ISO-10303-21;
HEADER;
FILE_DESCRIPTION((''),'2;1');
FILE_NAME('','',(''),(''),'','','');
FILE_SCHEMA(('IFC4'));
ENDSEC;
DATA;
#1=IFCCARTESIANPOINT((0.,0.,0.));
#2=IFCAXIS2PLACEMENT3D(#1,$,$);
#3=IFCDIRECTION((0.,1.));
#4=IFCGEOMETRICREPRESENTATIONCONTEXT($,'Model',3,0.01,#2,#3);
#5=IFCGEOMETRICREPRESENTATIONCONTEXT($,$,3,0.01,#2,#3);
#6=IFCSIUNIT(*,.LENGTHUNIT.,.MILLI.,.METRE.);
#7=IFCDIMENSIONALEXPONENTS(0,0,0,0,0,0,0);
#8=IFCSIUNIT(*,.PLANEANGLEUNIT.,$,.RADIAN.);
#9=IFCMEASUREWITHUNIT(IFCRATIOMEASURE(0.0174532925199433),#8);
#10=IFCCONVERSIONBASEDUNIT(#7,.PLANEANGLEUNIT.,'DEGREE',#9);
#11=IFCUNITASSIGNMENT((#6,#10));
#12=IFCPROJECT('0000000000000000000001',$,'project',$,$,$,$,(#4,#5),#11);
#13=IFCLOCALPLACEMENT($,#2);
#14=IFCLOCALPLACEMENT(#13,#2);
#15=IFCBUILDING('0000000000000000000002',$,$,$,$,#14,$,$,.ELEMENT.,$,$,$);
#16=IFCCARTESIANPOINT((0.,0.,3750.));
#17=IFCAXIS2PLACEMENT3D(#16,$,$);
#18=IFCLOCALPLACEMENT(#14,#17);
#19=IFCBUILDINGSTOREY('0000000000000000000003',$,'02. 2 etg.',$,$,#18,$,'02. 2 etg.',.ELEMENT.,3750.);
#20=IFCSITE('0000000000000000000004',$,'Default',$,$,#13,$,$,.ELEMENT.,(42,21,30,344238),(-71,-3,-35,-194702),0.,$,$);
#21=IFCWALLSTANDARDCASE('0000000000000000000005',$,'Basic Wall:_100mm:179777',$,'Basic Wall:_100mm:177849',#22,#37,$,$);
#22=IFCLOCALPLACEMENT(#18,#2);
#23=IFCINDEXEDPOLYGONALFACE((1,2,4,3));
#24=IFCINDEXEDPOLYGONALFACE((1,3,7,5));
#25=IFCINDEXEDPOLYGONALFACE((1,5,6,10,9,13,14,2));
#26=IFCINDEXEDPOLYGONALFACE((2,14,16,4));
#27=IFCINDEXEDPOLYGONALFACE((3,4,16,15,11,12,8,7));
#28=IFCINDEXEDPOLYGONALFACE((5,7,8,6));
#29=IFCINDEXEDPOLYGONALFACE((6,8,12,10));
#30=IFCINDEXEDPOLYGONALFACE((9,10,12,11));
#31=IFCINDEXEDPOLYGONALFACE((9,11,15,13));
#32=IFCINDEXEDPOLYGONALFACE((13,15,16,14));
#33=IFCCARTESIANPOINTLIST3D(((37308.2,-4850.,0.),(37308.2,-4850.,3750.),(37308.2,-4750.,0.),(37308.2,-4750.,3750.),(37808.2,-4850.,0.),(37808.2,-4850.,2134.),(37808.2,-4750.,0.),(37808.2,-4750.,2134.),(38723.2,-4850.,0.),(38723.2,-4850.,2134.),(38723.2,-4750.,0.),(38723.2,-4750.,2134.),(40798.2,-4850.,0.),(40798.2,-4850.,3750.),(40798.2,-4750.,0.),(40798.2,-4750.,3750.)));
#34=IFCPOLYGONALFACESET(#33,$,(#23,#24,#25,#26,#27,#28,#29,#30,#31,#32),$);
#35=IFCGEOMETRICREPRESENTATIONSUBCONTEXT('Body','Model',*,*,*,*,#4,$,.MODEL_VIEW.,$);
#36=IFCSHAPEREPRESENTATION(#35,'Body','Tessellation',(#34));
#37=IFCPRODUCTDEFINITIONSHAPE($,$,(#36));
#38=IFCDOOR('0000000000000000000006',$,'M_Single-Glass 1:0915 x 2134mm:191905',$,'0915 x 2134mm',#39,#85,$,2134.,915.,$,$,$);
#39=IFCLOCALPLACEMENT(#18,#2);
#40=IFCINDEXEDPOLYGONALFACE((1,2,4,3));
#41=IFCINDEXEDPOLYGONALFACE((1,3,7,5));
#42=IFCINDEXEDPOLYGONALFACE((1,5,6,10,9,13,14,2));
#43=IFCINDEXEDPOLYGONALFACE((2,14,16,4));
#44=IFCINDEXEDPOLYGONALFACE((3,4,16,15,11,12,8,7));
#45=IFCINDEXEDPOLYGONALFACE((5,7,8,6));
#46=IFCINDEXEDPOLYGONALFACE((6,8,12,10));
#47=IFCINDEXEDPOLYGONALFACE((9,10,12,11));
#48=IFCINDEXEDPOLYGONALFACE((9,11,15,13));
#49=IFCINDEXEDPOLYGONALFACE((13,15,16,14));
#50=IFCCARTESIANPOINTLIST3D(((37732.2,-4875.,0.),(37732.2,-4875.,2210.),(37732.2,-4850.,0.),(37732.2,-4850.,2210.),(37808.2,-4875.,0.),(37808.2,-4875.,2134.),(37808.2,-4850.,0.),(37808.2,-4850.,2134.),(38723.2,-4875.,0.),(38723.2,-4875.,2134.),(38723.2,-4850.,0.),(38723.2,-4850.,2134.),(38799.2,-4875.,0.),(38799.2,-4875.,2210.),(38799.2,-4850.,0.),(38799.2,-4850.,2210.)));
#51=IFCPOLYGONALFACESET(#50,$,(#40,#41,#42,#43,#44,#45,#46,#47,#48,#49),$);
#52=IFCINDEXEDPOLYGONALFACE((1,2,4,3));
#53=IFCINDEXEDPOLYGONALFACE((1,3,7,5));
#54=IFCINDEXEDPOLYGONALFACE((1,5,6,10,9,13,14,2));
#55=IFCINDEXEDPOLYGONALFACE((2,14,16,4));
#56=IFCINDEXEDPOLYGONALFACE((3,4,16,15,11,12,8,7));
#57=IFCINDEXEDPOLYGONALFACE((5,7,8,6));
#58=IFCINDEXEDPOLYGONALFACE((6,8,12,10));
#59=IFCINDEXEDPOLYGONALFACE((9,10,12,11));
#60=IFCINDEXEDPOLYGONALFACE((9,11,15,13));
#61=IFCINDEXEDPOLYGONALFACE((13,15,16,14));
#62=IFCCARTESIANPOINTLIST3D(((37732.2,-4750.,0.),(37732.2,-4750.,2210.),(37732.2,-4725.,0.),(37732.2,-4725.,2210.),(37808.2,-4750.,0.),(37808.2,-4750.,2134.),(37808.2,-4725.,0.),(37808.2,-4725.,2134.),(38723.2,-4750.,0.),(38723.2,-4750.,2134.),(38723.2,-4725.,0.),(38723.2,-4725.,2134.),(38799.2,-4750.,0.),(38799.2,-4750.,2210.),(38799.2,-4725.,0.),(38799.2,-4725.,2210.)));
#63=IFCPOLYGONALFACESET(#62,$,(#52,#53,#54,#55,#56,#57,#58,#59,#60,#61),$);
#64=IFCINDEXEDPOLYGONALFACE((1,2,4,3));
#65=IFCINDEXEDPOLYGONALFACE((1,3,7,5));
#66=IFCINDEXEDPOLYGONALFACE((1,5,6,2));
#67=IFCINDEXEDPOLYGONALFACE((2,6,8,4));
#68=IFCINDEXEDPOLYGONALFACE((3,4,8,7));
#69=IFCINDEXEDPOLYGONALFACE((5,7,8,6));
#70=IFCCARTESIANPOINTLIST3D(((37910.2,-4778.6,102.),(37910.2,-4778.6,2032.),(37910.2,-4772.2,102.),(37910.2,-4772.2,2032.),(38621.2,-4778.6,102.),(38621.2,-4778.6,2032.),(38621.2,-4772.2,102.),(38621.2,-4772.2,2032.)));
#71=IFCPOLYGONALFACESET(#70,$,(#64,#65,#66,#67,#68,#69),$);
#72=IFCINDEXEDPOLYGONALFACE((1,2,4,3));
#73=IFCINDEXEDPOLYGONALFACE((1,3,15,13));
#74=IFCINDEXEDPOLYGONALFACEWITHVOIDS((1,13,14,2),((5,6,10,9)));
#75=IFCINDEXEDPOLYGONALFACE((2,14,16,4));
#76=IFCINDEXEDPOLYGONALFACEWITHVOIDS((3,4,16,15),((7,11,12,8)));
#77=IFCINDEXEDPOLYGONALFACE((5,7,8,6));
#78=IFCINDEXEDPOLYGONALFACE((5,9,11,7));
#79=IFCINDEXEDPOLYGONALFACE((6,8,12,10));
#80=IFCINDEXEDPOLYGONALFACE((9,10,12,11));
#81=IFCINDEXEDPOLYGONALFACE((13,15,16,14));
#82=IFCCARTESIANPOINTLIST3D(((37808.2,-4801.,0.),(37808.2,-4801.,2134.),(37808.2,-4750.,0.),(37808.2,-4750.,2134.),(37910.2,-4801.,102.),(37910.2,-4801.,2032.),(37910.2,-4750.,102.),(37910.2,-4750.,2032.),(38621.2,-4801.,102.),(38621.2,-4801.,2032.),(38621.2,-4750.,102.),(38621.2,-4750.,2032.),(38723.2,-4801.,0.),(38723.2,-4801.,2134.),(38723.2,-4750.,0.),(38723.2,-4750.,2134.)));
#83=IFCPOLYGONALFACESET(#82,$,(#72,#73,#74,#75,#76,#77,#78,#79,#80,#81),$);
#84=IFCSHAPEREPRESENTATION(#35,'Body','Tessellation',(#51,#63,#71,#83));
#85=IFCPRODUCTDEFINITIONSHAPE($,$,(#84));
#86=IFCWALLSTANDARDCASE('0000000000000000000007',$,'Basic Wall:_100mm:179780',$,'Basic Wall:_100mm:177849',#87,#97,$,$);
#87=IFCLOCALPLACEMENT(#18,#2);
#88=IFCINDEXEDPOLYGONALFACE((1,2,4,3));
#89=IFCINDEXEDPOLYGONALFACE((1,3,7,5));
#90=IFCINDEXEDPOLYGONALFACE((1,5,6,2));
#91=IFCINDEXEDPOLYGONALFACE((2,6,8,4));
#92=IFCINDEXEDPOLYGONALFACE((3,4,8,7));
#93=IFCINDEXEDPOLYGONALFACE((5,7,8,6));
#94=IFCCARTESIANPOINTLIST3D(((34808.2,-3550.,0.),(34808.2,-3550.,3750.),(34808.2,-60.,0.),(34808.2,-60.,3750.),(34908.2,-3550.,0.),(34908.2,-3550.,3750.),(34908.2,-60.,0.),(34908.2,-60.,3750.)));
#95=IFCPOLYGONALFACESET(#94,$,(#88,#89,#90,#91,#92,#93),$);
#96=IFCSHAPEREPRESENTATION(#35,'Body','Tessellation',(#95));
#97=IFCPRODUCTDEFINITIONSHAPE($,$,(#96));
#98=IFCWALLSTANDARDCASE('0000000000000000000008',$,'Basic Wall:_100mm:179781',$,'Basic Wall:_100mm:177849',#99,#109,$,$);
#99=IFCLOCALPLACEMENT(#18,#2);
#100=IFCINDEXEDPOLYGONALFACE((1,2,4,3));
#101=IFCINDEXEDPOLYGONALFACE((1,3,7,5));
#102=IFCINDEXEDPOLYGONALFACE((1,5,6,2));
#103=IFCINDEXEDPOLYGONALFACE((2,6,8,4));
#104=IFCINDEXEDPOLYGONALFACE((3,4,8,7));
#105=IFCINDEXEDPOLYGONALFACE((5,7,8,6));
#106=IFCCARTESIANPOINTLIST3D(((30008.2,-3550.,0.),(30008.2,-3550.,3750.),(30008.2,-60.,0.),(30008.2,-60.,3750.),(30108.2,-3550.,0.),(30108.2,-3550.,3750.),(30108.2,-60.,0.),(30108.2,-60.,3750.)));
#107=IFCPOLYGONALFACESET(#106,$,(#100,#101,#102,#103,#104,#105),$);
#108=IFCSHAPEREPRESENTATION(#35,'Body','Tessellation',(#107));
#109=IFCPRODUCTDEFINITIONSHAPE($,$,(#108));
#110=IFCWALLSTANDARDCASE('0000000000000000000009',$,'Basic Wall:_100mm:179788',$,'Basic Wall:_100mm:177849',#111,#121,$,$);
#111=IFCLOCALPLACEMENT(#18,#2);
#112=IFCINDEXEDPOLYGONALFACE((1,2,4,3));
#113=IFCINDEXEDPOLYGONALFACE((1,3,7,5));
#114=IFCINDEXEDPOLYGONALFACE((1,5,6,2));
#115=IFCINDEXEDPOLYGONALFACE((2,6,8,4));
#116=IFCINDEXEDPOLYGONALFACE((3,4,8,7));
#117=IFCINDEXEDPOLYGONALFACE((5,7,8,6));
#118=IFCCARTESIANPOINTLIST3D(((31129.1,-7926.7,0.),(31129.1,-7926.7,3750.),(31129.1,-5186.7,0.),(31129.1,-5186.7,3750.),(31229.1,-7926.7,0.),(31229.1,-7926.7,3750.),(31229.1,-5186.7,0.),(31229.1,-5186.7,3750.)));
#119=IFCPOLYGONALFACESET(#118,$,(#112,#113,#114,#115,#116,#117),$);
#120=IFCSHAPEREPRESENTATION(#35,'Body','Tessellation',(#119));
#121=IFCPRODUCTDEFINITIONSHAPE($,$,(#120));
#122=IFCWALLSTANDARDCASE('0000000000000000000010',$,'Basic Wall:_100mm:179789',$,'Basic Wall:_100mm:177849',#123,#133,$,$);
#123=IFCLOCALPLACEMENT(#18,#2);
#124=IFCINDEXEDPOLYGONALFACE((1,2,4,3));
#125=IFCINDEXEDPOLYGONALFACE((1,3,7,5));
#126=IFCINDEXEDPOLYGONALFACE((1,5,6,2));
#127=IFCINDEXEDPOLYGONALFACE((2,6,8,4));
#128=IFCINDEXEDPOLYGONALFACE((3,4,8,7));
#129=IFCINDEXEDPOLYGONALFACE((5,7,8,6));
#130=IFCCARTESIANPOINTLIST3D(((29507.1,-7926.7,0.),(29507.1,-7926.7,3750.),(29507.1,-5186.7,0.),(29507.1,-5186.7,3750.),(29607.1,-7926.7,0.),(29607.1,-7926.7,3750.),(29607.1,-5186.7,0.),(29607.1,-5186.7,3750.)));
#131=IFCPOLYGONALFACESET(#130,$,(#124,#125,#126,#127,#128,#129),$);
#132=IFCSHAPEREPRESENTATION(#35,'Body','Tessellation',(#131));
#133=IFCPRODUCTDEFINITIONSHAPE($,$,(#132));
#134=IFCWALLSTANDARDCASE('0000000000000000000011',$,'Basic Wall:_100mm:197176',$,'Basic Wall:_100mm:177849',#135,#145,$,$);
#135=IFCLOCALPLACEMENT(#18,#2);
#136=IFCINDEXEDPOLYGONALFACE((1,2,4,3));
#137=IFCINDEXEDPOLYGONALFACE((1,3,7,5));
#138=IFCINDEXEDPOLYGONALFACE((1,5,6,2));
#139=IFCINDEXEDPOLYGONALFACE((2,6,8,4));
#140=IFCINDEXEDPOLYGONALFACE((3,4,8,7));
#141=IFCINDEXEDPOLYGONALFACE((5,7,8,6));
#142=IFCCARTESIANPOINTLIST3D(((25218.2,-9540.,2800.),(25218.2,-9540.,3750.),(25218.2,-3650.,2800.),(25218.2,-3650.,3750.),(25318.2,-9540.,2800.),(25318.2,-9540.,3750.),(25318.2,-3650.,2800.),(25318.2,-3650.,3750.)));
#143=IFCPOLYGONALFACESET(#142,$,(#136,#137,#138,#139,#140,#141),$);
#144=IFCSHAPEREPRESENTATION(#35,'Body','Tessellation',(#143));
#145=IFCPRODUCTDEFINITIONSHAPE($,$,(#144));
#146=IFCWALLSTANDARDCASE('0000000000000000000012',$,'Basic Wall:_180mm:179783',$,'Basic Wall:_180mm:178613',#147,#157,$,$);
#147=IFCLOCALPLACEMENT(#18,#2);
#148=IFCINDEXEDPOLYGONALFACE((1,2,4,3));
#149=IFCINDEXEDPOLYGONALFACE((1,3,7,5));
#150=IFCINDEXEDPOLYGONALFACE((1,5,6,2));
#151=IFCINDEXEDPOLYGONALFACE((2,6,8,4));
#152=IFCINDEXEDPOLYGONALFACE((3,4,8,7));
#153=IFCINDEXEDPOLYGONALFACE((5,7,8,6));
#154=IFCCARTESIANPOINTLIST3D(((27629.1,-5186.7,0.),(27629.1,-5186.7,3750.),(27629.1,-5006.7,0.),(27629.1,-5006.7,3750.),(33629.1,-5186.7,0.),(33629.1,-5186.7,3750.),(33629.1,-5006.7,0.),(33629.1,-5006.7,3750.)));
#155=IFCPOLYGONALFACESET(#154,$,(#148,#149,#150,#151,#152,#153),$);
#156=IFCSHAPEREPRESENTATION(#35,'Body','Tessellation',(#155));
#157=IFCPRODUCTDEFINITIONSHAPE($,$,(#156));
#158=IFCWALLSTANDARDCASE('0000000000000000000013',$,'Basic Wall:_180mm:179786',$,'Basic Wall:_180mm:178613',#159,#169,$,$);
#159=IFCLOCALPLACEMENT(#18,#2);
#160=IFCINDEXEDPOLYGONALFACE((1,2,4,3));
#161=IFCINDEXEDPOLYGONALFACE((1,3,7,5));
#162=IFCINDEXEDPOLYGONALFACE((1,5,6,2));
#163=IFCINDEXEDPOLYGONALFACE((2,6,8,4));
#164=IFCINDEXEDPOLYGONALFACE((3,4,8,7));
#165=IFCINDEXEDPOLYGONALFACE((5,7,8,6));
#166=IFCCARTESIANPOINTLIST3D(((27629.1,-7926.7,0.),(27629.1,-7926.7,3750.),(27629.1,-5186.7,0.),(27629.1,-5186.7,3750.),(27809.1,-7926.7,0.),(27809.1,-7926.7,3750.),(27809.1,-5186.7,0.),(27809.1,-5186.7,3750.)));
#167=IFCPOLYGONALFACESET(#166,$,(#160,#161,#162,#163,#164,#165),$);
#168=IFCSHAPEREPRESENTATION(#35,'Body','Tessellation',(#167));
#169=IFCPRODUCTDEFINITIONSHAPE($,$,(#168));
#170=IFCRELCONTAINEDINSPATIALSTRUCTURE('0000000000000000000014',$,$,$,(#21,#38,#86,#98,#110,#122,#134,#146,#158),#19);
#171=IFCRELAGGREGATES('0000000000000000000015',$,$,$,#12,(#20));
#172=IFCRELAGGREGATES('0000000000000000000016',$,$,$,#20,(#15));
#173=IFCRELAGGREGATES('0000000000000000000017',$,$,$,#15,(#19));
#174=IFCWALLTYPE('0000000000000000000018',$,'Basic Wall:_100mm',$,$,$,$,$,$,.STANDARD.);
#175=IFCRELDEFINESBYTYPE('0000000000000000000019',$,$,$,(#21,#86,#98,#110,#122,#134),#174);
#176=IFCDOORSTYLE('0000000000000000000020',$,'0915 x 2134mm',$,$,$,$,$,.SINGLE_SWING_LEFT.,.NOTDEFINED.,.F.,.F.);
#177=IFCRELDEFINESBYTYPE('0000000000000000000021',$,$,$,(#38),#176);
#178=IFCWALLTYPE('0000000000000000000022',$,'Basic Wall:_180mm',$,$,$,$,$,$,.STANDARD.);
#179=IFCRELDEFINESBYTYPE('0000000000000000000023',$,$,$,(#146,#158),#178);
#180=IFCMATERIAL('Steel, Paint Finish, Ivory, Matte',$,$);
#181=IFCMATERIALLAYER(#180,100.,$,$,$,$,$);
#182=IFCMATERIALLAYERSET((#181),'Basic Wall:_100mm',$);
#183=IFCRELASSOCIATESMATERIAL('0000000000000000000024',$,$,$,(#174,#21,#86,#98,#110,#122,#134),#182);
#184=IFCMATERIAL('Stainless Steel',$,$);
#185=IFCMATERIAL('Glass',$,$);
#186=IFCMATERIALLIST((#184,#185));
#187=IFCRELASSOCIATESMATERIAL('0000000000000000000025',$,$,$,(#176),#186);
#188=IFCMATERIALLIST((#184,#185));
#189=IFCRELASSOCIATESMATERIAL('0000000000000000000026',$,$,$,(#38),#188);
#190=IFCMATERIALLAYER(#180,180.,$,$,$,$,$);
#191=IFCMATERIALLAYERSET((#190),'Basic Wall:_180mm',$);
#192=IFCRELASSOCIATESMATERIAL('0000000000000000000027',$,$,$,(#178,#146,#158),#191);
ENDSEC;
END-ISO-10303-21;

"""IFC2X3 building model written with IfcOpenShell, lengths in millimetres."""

from ifc_helpers import new_model, entity, si_unit, converted_unit, direction, frame, frame_2d, origin, origin_2d_with_axis, place, context, subcontext, project, spatial, polyline, rectangle, outline, extrude, source, transform, mapped, material, material_list, layer, layer_set, layer_usage, type_object, type_shapes, element, fill, save


model = new_model("IFC2X3")

# Units and contexts
model_context = context("Model", 3, precision=0.01, world=origin(), true_north=direction((0.0, 1.0)))
context_of_model = context(None, 3, precision=0.01, world=origin(), true_north=direction((0.0, 1.0)))
body_context = subcontext(model_context, "Body", "Model", "MODEL_VIEW")
ifc_project = project(units=[si_unit("LENGTHUNIT", "METRE", prefix="MILLI"), converted_unit("PLANEANGLEUNIT", "DEGREE", entity("IfcRatioMeasure", 0.0174532925199433), si_unit("PLANEANGLEUNIT", "RADIAN"), dimensions=[0, 0, 0, 0, 0, 0, 0])], contexts=[model_context, context_of_model])

# Site, building, storey
site_placement = place(None, origin())
site = spatial("IfcSite", under=ifc_project, at=site_placement, Name="Default", CompositionType="ELEMENT", RefLatitude=(42, 21, 30, 344238), RefLongitude=(-71, -3, -35, -194702), RefElevation=0.0)
building_placement = place(site_placement, origin())
building = spatial("IfcBuilding", under=site, at=building_placement, CompositionType="ELEMENT")
storey_placement = place(building_placement, frame((0.0, 0.0, 3750.0)))
storey = spatial("IfcBuildingStorey", under=building, at=storey_placement, Name="02. 2 etg.", LongName="02. 2 etg.", CompositionType="ELEMENT", Elevation=3750.0)

# Shared definitions
ifc_material_1 = material(Name="Glass")
ifc_material_2 = material(Name="Stainless Steel")

# Shared definitions
ifc_material_3 = material(Name="Steel, Paint Finish, Ivory, Matte")
ifc_layer_1 = layer(ifc_material_3, 100.0)
ifc_layer_set_1 = layer_set([ifc_layer_1], Name="Basic Wall:_100mm")
wall_type_1 = type_object("IfcWallType", Name="Basic Wall:_100mm", PredefinedType="STANDARD", material=ifc_layer_set_1)

# Wall, opening, door
ifc_layer_usage_1 = layer_usage(ifc_layer_set_1, "AXIS2", "POSITIVE", -50.0)
wall_1_placement = place(storey_placement, frame((37308.2, -4800.0, 0.0)))
wall_1 = element("IfcWallStandardCase", 1, at=wall_1_placement, inside=storey, type_object=wall_type_1, material=ifc_layer_usage_1, Name="Basic Wall:_100mm:179777", ObjectType="Basic Wall:_100mm:177849", context=body_context, shape_type="SweptSolid", body=[
    extrude(rectangle(XDim=3490.0, YDim=100.0, at=frame_2d((1745.0, 0.0), x_axis=(-1.0, 0.0))), origin(), (0.0, 0.0, 1.0), 3750.0),
])
opening_1_placement = place(wall_1_placement, frame((500.0, -50.0, 0.0)))
opening_1 = element("IfcOpeningElement", 2, at=opening_1_placement, cuts=wall_1, ObjectType="Opening", context=body_context, shape_type="SweptSolid", body=[
    extrude(rectangle(XDim=915.0, YDim=2134.0, at=frame_2d((1067.0, 457.5), x_axis=(0.0, -1.0))), frame((0.0, 0.0, 0.0), z_axis=(0.0, 1.0, 0.0), x_axis=(0.0, 0.0, 1.0)), (0.0, 0.0, 1.0), 100.0),
])
ifc_material_list_1 = material_list([ifc_material_2, ifc_material_1])
ifc_material_list_2 = material_list([ifc_material_2, ifc_material_1])
door_style_1 = type_object("IfcDoorStyle", Name="0915 x 2134mm", ConstructionType="NOTDEFINED", OperationType="SINGLE_SWING_LEFT", ParameterTakesPrecedence=False, Sizeable=False, material=ifc_material_list_2)
shared_shape_1 = source(origin(), body_context, "Body", "SweptSolid", [
    extrude(outline(polyline([(-457.5, -1048.0), (-457.5, 1086.0), (-533.5, 1086.0), (-533.5, -1124.0), (533.5, -1124.0), (533.5, 1086.0), (457.5, 1086.0), (457.5, -1048.0), (-457.5, -1048.0)])), frame((457.5, 0.0, 1086.0), z_axis=(0.0, 1.0, 0.0), x_axis=(1.0, 0.0, 0.0)), (0.0, 0.0, -1.0), 25.0),
    extrude(outline(polyline([(-457.5, -1048.0), (-457.5, 1086.0), (-533.5, 1086.0), (-533.5, -1124.0), (533.5, -1124.0), (533.5, 1086.0), (457.5, 1086.0), (457.5, -1048.0), (-457.5, -1048.0)])), frame((457.5, 125.0, 1086.0), z_axis=(0.0, 1.0, 0.0), x_axis=(1.0, 0.0, 0.0)), (0.0, 0.0, -1.0), 25.0),
    extrude(rectangle(XDim=711.0, YDim=6.3, at=origin_2d_with_axis()), frame((457.5, 74.6, 102.0)), (0.0, 0.0, 1.0), 1930.0),
    extrude(outline(polyline([(-1067.0, -457.5), (1067.0, -457.5), (1067.0, 457.5), (-1067.0, 457.5), (-1067.0, -457.5)]), holes=[polyline([(-965.0, 355.5), (965.0, 355.5), (965.0, -355.5), (-965.0, -355.5), (-965.0, 355.5)])]), frame((457.5, 100.0, 1067.0), z_axis=(0.0, -1.0, 0.0), x_axis=(0.0, 0.0, -1.0)), (0.0, 0.0, 1.0), 51.0),
])
type_shapes(door_style_1, [shared_shape_1])
door_1_placement = place(opening_1_placement, origin())
door_1 = element("IfcDoor", 3, at=door_1_placement, inside=storey, type_object=door_style_1, material=ifc_material_list_1, Name="M_Single-Glass 1:0915 x 2134mm:191905", ObjectType="0915 x 2134mm", OverallHeight=2134.0, OverallWidth=915.0, context=body_context, shape_type="MappedRepresentation", body=[
    mapped(shared_shape_1, transform((0.0, 0.0, 0.0), scale=1.0)),
])
fill(opening_1, door_1)

# Walls
ifc_layer_usage_2 = layer_usage(ifc_layer_set_1, "AXIS2", "POSITIVE", -50.0)
wall_2_placement = place(storey_placement, frame((34858.2, -3550.0, 0.0), z_axis=(0.0, 0.0, 1.0), x_axis=(0.0, 1.0, 0.0)))
element("IfcWallStandardCase", 4, at=wall_2_placement, inside=storey, type_object=wall_type_1, material=ifc_layer_usage_2, Name="Basic Wall:_100mm:179780", ObjectType="Basic Wall:_100mm:177849", context=body_context, shape_type="SweptSolid", body=[
    extrude(rectangle(XDim=3490.0, YDim=100.0, at=frame_2d((1745.0, 0.0), x_axis=(-1.0, 0.0))), origin(), (0.0, 0.0, 1.0), 3750.0),
])
ifc_layer_usage_3 = layer_usage(ifc_layer_set_1, "AXIS2", "POSITIVE", -50.0)
wall_3_placement = place(storey_placement, frame((30058.2, -3550.0, 0.0), z_axis=(0.0, 0.0, 1.0), x_axis=(0.0, 1.0, 0.0)))
element("IfcWallStandardCase", 5, at=wall_3_placement, inside=storey, type_object=wall_type_1, material=ifc_layer_usage_3, Name="Basic Wall:_100mm:179781", ObjectType="Basic Wall:_100mm:177849", context=body_context, shape_type="SweptSolid", body=[
    extrude(rectangle(XDim=3490.0, YDim=100.0, at=frame_2d((1745.0, 0.0), x_axis=(-1.0, 0.0))), origin(), (0.0, 0.0, 1.0), 3750.0),
])
ifc_layer_usage_4 = layer_usage(ifc_layer_set_1, "AXIS2", "NEGATIVE", 50.0)
wall_4_placement = place(storey_placement, frame((31179.1, -5186.7, 0.0), z_axis=(0.0, 0.0, 1.0), x_axis=(0.0, -1.0, 0.0)))
element("IfcWallStandardCase", 6, at=wall_4_placement, inside=storey, type_object=wall_type_1, material=ifc_layer_usage_4, Name="Basic Wall:_100mm:179788", ObjectType="Basic Wall:_100mm:177849", context=body_context, shape_type="SweptSolid", body=[
    extrude(rectangle(XDim=2740.0, YDim=100.0, at=frame_2d((1370.0, 0.0), x_axis=(-1.0, 0.0))), origin(), (0.0, 0.0, 1.0), 3750.0),
])
ifc_layer_usage_5 = layer_usage(ifc_layer_set_1, "AXIS2", "POSITIVE", -50.0)
wall_5_placement = place(storey_placement, frame((29557.1, -5186.7, 0.0), z_axis=(0.0, 0.0, 1.0), x_axis=(0.0, -1.0, 0.0)))
element("IfcWallStandardCase", 7, at=wall_5_placement, inside=storey, type_object=wall_type_1, material=ifc_layer_usage_5, Name="Basic Wall:_100mm:179789", ObjectType="Basic Wall:_100mm:177849", context=body_context, shape_type="SweptSolid", body=[
    extrude(rectangle(XDim=2740.0, YDim=100.0, at=frame_2d((1370.0, 0.0), x_axis=(-1.0, 0.0))), origin(), (0.0, 0.0, 1.0), 3750.0),
])
ifc_layer_usage_6 = layer_usage(ifc_layer_set_1, "AXIS2", "NEGATIVE", 50.0)
wall_6_placement = place(storey_placement, frame((25268.2, -3650.0, 2800.0), z_axis=(0.0, 0.0, 1.0), x_axis=(0.0, -1.0, 0.0)))
element("IfcWallStandardCase", 8, at=wall_6_placement, inside=storey, type_object=wall_type_1, material=ifc_layer_usage_6, Name="Basic Wall:_100mm:197176", ObjectType="Basic Wall:_100mm:177849", context=body_context, shape_type="SweptSolid", body=[
    extrude(rectangle(XDim=5890.0, YDim=100.0, at=frame_2d((2945.0, 0.0), x_axis=(-1.0, 0.0))), origin(), (0.0, 0.0, 1.0), 950.0),
])
ifc_layer_2 = layer(ifc_material_3, 180.0)
ifc_layer_set_2 = layer_set([ifc_layer_2], Name="Basic Wall:_180mm")
ifc_layer_usage_7 = layer_usage(ifc_layer_set_2, "AXIS2", "POSITIVE", -90.0)
wall_type_2 = type_object("IfcWallType", Name="Basic Wall:_180mm", PredefinedType="STANDARD", material=ifc_layer_set_2)
wall_7_placement = place(storey_placement, frame((33629.1, -5096.7, 0.0), z_axis=(0.0, 0.0, 1.0), x_axis=(-1.0, 0.0, 0.0)))
element("IfcWallStandardCase", 9, at=wall_7_placement, inside=storey, type_object=wall_type_2, material=ifc_layer_usage_7, Name="Basic Wall:_180mm:179783", ObjectType="Basic Wall:_180mm:178613", context=body_context, shape_type="SweptSolid", body=[
    extrude(rectangle(XDim=6000.0, YDim=180.0, at=frame_2d((3000.0, 0.0), x_axis=(-1.0, 0.0))), origin(), (0.0, 0.0, 1.0), 3750.0),
])
ifc_layer_usage_8 = layer_usage(ifc_layer_set_2, "AXIS2", "POSITIVE", -90.0)
wall_8_placement = place(storey_placement, frame((27719.1, -5186.7, 0.0), z_axis=(0.0, 0.0, 1.0), x_axis=(0.0, -1.0, 0.0)))
element("IfcWallStandardCase", 10, at=wall_8_placement, inside=storey, type_object=wall_type_2, material=ifc_layer_usage_8, Name="Basic Wall:_180mm:179786", ObjectType="Basic Wall:_180mm:178613", context=body_context, shape_type="SweptSolid", body=[
    extrude(rectangle(XDim=2740.0, YDim=180.0, at=frame_2d((1370.0, 0.0), x_axis=(-1.0, 0.0))), origin(), (0.0, 0.0, 1.0), 3750.0),
])

save(model, "model.ifc")
